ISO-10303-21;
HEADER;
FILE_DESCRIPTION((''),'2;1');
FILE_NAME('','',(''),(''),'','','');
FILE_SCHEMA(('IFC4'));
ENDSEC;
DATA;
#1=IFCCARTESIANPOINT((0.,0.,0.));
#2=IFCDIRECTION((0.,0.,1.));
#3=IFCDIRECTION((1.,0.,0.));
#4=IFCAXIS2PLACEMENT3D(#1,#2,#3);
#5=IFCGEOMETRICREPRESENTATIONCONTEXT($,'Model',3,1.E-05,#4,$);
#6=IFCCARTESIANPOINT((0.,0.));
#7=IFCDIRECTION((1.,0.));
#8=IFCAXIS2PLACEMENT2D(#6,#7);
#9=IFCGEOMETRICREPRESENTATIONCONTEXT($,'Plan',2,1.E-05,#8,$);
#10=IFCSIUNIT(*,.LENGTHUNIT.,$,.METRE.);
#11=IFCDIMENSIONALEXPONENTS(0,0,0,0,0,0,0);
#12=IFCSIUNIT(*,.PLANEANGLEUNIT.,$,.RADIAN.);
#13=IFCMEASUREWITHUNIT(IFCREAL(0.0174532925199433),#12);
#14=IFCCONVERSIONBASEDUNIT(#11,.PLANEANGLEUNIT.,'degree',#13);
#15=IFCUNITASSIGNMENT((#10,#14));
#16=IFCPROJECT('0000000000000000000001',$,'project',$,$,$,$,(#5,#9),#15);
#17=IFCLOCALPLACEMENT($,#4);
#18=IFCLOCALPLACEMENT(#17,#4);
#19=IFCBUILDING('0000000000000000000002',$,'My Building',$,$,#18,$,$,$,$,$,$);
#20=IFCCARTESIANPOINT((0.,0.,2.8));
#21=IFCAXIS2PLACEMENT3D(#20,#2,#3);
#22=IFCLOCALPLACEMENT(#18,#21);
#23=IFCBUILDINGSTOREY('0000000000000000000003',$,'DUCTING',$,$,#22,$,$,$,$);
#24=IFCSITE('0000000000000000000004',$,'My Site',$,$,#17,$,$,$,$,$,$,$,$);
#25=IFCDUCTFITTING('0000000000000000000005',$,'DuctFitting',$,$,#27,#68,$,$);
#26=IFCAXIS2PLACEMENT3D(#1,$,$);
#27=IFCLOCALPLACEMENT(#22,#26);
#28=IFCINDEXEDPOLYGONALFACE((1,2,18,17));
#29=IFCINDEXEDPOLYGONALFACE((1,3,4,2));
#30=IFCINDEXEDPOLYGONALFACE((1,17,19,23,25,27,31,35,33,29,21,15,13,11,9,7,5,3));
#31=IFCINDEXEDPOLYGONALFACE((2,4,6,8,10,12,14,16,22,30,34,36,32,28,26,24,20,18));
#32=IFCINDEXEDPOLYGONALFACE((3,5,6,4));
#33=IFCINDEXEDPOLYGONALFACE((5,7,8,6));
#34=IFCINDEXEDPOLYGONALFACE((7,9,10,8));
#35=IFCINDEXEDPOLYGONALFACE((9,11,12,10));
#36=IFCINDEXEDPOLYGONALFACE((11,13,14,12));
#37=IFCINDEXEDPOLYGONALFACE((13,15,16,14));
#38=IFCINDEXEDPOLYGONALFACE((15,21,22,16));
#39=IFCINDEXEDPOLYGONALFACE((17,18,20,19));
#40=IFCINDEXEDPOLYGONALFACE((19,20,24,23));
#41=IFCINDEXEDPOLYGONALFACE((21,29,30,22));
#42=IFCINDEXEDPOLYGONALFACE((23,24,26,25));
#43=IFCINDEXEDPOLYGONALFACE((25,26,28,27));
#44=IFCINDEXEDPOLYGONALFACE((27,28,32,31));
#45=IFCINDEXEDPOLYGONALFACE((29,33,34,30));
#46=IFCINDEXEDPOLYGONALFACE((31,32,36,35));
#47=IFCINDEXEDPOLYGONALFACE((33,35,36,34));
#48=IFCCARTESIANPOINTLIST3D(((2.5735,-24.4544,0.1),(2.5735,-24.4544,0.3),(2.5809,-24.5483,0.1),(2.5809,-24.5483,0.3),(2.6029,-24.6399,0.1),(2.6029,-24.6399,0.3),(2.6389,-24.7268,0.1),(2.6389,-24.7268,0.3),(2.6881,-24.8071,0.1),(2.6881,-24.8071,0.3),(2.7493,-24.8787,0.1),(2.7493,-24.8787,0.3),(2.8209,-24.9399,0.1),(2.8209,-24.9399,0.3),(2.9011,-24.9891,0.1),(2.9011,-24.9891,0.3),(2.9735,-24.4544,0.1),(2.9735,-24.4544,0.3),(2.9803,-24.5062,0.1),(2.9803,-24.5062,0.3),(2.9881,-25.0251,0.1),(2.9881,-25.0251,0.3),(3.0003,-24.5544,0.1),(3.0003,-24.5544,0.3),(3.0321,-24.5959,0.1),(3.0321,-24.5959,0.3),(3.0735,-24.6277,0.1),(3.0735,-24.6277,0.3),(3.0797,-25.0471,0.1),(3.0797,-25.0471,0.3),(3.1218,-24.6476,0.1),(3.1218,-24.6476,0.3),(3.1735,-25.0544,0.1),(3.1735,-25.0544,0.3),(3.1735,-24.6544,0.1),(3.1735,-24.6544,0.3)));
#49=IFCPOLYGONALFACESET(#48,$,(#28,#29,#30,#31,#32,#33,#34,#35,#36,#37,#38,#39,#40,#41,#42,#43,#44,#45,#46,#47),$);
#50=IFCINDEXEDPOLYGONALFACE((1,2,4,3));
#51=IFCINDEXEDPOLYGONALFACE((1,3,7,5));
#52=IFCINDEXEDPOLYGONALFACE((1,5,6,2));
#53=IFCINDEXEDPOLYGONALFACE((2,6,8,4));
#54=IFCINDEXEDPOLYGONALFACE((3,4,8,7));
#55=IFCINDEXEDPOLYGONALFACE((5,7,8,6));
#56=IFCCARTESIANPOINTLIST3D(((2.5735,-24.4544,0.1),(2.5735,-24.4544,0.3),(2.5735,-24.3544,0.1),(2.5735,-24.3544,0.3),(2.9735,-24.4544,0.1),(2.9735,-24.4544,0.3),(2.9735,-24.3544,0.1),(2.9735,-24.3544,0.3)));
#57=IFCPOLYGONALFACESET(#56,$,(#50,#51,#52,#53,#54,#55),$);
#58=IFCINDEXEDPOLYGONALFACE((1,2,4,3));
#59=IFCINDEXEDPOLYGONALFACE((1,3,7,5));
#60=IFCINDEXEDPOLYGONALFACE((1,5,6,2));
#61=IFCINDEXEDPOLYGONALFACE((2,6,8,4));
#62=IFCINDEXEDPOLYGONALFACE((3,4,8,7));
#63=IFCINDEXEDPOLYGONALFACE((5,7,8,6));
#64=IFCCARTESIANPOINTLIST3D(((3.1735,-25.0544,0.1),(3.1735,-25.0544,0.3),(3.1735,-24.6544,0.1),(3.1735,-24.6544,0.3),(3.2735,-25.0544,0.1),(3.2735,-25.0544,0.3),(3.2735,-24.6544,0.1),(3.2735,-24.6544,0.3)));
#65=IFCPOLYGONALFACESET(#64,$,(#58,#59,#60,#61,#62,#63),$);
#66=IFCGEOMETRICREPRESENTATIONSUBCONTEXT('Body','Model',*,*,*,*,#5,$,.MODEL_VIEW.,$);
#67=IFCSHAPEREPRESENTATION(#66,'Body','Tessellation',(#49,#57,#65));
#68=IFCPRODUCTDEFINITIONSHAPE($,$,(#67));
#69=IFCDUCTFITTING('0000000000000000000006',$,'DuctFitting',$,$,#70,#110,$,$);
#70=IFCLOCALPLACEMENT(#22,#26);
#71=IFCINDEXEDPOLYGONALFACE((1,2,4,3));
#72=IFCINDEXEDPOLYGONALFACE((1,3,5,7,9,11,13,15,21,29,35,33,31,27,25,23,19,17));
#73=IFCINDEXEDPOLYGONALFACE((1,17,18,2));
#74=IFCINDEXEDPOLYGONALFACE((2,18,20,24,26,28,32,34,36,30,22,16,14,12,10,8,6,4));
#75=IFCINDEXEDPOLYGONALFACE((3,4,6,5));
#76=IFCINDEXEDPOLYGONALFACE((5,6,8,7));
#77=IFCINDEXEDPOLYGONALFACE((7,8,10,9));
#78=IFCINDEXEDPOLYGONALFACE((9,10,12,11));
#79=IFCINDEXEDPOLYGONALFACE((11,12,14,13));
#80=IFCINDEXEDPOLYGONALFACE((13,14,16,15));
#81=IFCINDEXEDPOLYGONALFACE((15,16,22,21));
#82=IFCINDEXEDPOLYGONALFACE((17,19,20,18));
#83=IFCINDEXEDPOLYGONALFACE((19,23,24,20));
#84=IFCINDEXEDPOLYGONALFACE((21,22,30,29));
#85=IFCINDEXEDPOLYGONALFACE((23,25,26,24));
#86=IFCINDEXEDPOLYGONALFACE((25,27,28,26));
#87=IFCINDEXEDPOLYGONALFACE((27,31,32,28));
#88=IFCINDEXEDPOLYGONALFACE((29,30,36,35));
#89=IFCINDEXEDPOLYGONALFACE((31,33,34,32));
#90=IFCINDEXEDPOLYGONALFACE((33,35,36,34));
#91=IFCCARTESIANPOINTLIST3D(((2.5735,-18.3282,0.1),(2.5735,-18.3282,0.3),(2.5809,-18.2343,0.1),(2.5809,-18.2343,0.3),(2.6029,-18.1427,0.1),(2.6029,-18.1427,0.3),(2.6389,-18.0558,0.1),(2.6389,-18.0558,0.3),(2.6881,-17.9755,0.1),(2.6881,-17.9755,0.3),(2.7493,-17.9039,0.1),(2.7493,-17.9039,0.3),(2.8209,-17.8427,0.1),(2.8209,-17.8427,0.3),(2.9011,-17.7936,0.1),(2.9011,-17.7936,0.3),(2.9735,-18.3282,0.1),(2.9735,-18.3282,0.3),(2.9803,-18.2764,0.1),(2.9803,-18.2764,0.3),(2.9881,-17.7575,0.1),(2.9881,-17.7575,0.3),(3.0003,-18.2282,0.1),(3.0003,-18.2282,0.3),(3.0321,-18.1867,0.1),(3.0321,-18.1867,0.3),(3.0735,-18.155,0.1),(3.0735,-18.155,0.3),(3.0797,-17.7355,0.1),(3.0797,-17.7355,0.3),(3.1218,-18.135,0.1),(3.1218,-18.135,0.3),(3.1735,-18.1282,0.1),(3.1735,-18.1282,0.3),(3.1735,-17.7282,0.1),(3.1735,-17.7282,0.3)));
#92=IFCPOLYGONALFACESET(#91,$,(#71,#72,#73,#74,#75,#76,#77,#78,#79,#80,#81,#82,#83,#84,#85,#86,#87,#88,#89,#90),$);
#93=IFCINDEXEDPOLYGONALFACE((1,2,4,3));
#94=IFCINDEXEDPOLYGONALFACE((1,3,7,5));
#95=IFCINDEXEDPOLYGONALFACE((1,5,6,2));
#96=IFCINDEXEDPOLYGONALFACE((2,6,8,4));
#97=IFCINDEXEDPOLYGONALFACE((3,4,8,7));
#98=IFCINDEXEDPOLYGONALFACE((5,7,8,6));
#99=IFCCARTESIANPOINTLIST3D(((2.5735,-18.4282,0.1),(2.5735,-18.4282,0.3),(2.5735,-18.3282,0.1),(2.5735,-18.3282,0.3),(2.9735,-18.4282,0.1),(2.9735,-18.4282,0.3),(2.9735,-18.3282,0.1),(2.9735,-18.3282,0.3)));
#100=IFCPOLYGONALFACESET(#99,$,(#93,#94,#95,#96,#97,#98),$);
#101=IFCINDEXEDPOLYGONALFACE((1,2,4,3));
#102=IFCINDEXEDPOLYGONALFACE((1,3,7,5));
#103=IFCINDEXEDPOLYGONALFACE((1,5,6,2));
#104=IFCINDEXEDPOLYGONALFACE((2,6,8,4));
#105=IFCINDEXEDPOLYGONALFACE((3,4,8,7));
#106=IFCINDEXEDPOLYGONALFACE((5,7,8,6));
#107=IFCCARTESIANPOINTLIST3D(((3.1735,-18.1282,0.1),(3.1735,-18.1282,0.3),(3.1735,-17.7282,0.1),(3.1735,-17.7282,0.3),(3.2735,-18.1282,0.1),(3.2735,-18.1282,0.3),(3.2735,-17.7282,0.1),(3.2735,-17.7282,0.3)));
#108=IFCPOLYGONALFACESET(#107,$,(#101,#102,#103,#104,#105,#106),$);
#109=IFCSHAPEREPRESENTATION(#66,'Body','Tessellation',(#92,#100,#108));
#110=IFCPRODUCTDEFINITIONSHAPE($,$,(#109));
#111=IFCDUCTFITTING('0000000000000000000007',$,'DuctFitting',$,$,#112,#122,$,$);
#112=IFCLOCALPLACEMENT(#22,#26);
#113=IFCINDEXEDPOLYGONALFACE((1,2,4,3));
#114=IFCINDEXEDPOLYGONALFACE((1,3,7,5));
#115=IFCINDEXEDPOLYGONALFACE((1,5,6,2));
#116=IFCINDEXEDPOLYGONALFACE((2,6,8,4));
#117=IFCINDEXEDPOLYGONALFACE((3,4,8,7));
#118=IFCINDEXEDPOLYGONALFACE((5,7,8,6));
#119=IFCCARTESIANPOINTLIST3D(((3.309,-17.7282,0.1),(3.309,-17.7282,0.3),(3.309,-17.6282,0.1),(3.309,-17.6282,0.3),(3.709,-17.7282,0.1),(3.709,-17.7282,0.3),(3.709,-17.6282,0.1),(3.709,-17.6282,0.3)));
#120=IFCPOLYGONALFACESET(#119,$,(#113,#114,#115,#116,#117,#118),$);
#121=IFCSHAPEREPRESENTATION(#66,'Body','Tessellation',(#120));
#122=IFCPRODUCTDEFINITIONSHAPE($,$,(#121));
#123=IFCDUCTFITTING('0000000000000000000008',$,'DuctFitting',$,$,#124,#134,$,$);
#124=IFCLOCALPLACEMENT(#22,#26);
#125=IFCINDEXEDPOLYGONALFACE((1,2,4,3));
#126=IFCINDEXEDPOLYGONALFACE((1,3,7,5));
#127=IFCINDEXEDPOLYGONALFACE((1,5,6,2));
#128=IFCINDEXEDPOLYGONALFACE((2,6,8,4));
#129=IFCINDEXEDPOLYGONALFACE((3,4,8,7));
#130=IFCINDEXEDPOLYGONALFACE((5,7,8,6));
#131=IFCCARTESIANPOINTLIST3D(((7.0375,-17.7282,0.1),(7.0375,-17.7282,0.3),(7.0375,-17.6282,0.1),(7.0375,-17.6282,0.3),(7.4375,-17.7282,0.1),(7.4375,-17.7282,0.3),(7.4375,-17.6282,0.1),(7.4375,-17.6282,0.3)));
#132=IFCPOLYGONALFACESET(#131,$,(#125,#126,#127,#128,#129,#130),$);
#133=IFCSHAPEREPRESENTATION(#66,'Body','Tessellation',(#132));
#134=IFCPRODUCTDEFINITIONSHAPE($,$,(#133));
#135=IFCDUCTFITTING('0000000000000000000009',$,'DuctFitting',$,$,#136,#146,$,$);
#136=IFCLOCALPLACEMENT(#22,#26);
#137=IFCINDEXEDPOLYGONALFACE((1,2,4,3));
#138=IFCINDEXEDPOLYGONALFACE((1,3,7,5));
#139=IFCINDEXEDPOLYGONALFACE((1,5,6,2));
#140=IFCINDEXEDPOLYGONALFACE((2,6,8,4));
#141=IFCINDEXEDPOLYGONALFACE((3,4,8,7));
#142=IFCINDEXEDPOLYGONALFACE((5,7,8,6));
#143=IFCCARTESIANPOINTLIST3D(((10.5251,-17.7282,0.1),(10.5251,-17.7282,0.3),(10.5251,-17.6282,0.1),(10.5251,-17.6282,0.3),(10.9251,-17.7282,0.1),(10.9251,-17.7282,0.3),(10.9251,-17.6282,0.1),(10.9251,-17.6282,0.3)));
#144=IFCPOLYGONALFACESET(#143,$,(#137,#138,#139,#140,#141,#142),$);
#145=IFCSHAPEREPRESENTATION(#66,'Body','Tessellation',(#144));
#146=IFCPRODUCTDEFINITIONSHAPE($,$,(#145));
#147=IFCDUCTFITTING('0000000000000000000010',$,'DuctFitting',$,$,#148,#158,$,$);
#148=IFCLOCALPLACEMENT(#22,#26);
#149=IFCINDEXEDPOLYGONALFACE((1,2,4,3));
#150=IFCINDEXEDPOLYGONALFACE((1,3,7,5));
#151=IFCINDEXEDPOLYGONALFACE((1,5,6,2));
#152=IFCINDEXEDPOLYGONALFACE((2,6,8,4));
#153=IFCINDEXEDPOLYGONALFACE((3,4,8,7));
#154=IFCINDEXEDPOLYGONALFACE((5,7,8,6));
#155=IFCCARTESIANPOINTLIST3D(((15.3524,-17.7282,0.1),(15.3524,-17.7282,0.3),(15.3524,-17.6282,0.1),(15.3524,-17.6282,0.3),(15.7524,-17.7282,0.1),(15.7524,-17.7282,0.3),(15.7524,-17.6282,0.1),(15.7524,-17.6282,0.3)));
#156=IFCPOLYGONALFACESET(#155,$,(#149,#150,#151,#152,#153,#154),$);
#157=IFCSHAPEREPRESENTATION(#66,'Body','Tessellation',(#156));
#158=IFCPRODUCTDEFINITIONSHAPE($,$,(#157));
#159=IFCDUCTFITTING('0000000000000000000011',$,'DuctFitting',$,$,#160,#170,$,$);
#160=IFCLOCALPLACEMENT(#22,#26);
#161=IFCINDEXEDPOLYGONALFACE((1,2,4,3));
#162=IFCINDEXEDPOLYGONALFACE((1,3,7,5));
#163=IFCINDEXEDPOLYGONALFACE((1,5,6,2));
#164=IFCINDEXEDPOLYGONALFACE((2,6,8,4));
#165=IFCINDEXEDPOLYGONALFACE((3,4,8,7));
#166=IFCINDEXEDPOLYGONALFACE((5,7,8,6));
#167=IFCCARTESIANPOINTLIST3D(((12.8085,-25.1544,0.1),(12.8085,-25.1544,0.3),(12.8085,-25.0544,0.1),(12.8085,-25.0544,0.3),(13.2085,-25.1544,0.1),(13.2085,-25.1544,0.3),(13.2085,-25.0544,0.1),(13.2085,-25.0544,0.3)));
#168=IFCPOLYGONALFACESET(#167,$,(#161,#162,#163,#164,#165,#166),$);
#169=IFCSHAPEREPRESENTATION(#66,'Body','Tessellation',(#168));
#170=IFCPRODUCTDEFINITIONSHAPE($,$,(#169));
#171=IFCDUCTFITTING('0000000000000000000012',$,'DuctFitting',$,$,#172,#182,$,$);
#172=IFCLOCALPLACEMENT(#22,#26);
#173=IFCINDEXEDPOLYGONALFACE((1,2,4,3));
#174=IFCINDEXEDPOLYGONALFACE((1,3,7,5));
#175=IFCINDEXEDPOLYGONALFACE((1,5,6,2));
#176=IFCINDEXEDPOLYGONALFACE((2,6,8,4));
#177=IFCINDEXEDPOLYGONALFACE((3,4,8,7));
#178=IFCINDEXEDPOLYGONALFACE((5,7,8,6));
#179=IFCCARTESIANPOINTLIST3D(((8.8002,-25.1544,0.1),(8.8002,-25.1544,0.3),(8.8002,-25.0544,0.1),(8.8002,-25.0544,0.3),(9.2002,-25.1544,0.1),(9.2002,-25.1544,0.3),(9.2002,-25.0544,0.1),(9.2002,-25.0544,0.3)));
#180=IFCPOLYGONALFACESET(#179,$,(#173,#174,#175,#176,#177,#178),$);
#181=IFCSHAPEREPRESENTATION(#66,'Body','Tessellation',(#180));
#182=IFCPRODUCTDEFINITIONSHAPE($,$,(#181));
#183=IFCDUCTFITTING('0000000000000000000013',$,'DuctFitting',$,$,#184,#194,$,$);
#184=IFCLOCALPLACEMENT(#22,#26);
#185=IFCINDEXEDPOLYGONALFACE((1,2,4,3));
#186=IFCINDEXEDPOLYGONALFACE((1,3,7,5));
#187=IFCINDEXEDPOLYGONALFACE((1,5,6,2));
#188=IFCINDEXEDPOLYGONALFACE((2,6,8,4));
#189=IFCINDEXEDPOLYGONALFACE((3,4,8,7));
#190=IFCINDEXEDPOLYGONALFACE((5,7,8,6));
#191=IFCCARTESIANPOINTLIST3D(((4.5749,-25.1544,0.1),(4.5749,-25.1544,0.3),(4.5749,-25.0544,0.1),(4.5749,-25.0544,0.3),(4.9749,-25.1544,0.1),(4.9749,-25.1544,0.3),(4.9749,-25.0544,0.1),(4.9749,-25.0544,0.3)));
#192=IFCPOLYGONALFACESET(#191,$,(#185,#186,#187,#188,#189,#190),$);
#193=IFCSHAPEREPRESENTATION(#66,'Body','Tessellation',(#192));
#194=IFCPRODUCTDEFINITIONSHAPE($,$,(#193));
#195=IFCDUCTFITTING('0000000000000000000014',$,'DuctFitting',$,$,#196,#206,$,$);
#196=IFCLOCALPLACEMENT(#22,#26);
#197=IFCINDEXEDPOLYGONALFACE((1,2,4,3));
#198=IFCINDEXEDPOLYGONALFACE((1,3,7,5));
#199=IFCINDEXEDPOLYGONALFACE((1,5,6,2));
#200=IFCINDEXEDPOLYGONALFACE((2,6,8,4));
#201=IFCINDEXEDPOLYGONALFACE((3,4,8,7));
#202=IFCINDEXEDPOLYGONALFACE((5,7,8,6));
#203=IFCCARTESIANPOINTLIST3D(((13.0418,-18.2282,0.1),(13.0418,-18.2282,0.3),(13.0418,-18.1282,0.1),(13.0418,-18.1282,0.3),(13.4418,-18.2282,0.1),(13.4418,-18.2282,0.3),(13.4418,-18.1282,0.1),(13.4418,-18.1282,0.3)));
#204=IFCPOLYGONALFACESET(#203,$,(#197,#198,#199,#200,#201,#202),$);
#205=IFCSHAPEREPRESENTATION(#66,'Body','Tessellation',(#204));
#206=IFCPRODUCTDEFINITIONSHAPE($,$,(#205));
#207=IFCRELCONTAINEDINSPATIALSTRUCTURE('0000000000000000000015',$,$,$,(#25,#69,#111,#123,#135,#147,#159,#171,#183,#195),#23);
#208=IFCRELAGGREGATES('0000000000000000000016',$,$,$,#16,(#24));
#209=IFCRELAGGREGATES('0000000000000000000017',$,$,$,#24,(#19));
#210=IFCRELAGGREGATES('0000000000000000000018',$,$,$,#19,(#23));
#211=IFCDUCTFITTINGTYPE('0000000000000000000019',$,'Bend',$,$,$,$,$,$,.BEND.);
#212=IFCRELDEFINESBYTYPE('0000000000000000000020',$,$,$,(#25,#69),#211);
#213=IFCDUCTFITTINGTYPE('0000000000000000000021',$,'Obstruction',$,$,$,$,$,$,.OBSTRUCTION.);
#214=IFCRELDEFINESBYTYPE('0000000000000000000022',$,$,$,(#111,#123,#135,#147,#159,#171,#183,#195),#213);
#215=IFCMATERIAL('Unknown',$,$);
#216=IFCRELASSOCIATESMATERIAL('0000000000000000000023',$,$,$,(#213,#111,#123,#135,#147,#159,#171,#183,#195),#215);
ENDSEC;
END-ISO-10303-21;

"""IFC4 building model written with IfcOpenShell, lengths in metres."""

from ifc_helpers import new_model, entity, si_unit, converted_unit, frame, origin_with_axes, origin_2d_with_axis, place, context, subcontext, project, spatial, line, arc, indexed_curve, rectangle, outline, extrude, source, transform, mapped, material, material_profile, profile_set, profile_usage, type_object, type_shapes, element, save


model = new_model("IFC4")

# Units and contexts
model_context = context("Model", 3, precision=1e-05, world=origin_with_axes())
plan_context = context("Plan", 2, precision=1e-05, world=origin_2d_with_axis())
body_context = subcontext(model_context, "Body", "Model", "MODEL_VIEW")
ifc_project = project(units=[si_unit("LENGTHUNIT", "METRE"), converted_unit("PLANEANGLEUNIT", "degree", entity("IfcReal", 0.0174532925199433), si_unit("PLANEANGLEUNIT", "RADIAN"), dimensions=[0, 0, 0, 0, 0, 0, 0])], contexts=[model_context, plan_context])

# Site, building, storey
site_placement = place(None, origin_with_axes())
site = spatial("IfcSite", under=ifc_project, at=site_placement, Name="My Site")
building_placement = place(site_placement, origin_with_axes())
building = spatial("IfcBuilding", under=site, at=building_placement, Name="My Building")
storey_placement = place(building_placement, frame((0.0, 0.0, 2.8), z_axis=(0.0, 0.0, 1.0), x_axis=(1.0, 0.0, 0.0)))
storey = spatial("IfcBuildingStorey", under=building, at=storey_placement, Name="DUCTING")

# Shared definitions
ifc_material = material(Name="Unknown")

# Duct fittings
duct_fitting_type_1 = type_object("IfcDuctFittingType", Name="Bend", PredefinedType="BEND")
shared_shape = source(origin_with_axes(), body_context, "Body", "SweptSolid", [
    extrude(outline(indexed_curve([(0.2, 0.0), (0.2586, 0.1414), (0.4, 0.2), (0.4, 0.6), (-0.0243, 0.4243), (-0.2, 0.0)], segments=[arc(1, 2, 3), line(3, 4), arc(4, 5, 6), line(6, 1)])), frame((0.0, -0.1, 0.1), z_axis=(0.0, -1.0, 0.0), x_axis=(1.0, 0.0, 0.0)), (0.0, 0.0, -1.0), 0.2),
    extrude(rectangle(XDim=0.4, YDim=0.2), origin_with_axes(), (0.0, 0.0, 1.0), 0.1),
    extrude(rectangle(XDim=0.4, YDim=0.2), frame((0.4, 0.0, 0.5), z_axis=(1.0, 0.0, -0.000001), x_axis=(0.000001, 0.0, 1.0)), (0.0, 0.0, 1.0), 0.1),
])
type_shapes(duct_fitting_type_1, [shared_shape])
for number, where, z_axis, x_axis, name in (
    (1, (2.7735, -24.3544, 0.2), (0.0, -1.0, 0.0), (1.0, 0.0, 0.0), "DuctFitting"),
    (2, (2.7735, -18.4282, 0.2), (0.0, 1.0, 0.0), (1.0, 0.0, 0.0), "DuctFitting"),
):
    element("IfcDuctFitting", number, at=place(storey_placement, frame(where, z_axis=z_axis, x_axis=x_axis)), inside=storey, type_object=duct_fitting_type_1, Name=name, context=body_context, shape_type="MappedRepresentation", body=[
        mapped(shared_shape, transform((0.0, 0.0, 0.0), x_axis=(1.0, 0.0, 0.0), y_axis=(0.0, 1.0, 0.0), z_axis=(0.0, 0.0, 1.0), scale=1.0)),
    ])
ifc_material_profile_1 = material_profile(ifc_material, rectangle(XDim=0.4, YDim=0.2))
ifc_profile_set_1 = profile_set([ifc_material_profile_1])
ifc_profile_usage_1 = profile_usage(ifc_profile_set_1, cardinal=5)
duct_fitting_type_2 = type_object("IfcDuctFittingType", Name="Obstruction", PredefinedType="OBSTRUCTION", material=ifc_profile_set_1)
duct_fitting_1_placement = place(storey_placement, frame((3.509, -17.6282, 0.2), z_axis=(0.0, -1.0, 0.0), x_axis=(1.0, 0.0, 0.0)))
element("IfcDuctFitting", 3, at=duct_fitting_1_placement, inside=storey, type_object=duct_fitting_type_2, material=ifc_profile_usage_1, Name="DuctFitting", context=body_context, shape_type="SweptSolid", body=[
    extrude(rectangle(XDim=0.4, YDim=0.2), origin_with_axes(), (0.0, 0.0, 1.0), 0.1),
])
ifc_profile_usage_2 = profile_usage(ifc_profile_set_1, cardinal=5)
duct_fitting_2_placement = place(storey_placement, frame((7.2375, -17.6282, 0.2), z_axis=(0.0, -1.0, 0.0), x_axis=(1.0, 0.0, 0.0)))
element("IfcDuctFitting", 4, at=duct_fitting_2_placement, inside=storey, type_object=duct_fitting_type_2, material=ifc_profile_usage_2, Name="DuctFitting", context=body_context, shape_type="SweptSolid", body=[
    extrude(rectangle(XDim=0.4, YDim=0.2), origin_with_axes(), (0.0, 0.0, 1.0), 0.1),
])
ifc_profile_usage_3 = profile_usage(ifc_profile_set_1, cardinal=5)
duct_fitting_3_placement = place(storey_placement, frame((10.7251, -17.6282, 0.2), z_axis=(0.0, -1.0, 0.0), x_axis=(1.0, 0.0, 0.0)))
element("IfcDuctFitting", 5, at=duct_fitting_3_placement, inside=storey, type_object=duct_fitting_type_2, material=ifc_profile_usage_3, Name="DuctFitting", context=body_context, shape_type="SweptSolid", body=[
    extrude(rectangle(XDim=0.4, YDim=0.2), origin_with_axes(), (0.0, 0.0, 1.0), 0.1),
])
ifc_profile_usage_4 = profile_usage(ifc_profile_set_1, cardinal=5)
duct_fitting_4_placement = place(storey_placement, frame((15.5524, -17.6282, 0.2), z_axis=(0.0, -1.0, 0.0), x_axis=(1.0, 0.0, 0.0)))
element("IfcDuctFitting", 6, at=duct_fitting_4_placement, inside=storey, type_object=duct_fitting_type_2, material=ifc_profile_usage_4, Name="DuctFitting", context=body_context, shape_type="SweptSolid", body=[
    extrude(rectangle(XDim=0.4, YDim=0.2), origin_with_axes(), (0.0, 0.0, 1.0), 0.1),
])
ifc_profile_usage_5 = profile_usage(ifc_profile_set_1, cardinal=5)
duct_fitting_5_placement = place(storey_placement, frame((13.0085, -25.1544, 0.2), z_axis=(0.000001, 1.0, 0.0), x_axis=(-1.0, 0.000001, 0.0)))
element("IfcDuctFitting", 7, at=duct_fitting_5_placement, inside=storey, type_object=duct_fitting_type_2, material=ifc_profile_usage_5, Name="DuctFitting", context=body_context, shape_type="SweptSolid", body=[
    extrude(rectangle(XDim=0.4, YDim=0.2), origin_with_axes(), (0.0, 0.0, 1.0), 0.1),
])
ifc_profile_usage_6 = profile_usage(ifc_profile_set_1, cardinal=5)
duct_fitting_6_placement = place(storey_placement, frame((9.0002, -25.1544, 0.2), z_axis=(0.000001, 1.0, 0.0), x_axis=(-1.0, 0.000001, 0.0)))
element("IfcDuctFitting", 8, at=duct_fitting_6_placement, inside=storey, type_object=duct_fitting_type_2, material=ifc_profile_usage_6, Name="DuctFitting", context=body_context, shape_type="SweptSolid", body=[
    extrude(rectangle(XDim=0.4, YDim=0.2), origin_with_axes(), (0.0, 0.0, 1.0), 0.1),
])
ifc_profile_usage_7 = profile_usage(ifc_profile_set_1, cardinal=5)
duct_fitting_7_placement = place(storey_placement, frame((4.7749, -25.1544, 0.2), z_axis=(0.000001, 1.0, 0.0), x_axis=(-1.0, 0.000001, 0.0)))
element("IfcDuctFitting", 9, at=duct_fitting_7_placement, inside=storey, type_object=duct_fitting_type_2, material=ifc_profile_usage_7, Name="DuctFitting", context=body_context, shape_type="SweptSolid", body=[
    extrude(rectangle(XDim=0.4, YDim=0.2), origin_with_axes(), (0.0, 0.0, 1.0), 0.1),
])
ifc_profile_usage_8 = profile_usage(ifc_profile_set_1, cardinal=5)
duct_fitting_8_placement = place(storey_placement, frame((13.2418, -18.2282, 0.2), z_axis=(0.000001, 1.0, 0.0), x_axis=(-1.0, 0.000001, 0.0)))
element("IfcDuctFitting", 10, at=duct_fitting_8_placement, inside=storey, type_object=duct_fitting_type_2, material=ifc_profile_usage_8, Name="DuctFitting", context=body_context, shape_type="SweptSolid", body=[
    extrude(rectangle(XDim=0.4, YDim=0.2), origin_with_axes(), (0.0, 0.0, 1.0), 0.1),
])

save(model, "model.ifc")
